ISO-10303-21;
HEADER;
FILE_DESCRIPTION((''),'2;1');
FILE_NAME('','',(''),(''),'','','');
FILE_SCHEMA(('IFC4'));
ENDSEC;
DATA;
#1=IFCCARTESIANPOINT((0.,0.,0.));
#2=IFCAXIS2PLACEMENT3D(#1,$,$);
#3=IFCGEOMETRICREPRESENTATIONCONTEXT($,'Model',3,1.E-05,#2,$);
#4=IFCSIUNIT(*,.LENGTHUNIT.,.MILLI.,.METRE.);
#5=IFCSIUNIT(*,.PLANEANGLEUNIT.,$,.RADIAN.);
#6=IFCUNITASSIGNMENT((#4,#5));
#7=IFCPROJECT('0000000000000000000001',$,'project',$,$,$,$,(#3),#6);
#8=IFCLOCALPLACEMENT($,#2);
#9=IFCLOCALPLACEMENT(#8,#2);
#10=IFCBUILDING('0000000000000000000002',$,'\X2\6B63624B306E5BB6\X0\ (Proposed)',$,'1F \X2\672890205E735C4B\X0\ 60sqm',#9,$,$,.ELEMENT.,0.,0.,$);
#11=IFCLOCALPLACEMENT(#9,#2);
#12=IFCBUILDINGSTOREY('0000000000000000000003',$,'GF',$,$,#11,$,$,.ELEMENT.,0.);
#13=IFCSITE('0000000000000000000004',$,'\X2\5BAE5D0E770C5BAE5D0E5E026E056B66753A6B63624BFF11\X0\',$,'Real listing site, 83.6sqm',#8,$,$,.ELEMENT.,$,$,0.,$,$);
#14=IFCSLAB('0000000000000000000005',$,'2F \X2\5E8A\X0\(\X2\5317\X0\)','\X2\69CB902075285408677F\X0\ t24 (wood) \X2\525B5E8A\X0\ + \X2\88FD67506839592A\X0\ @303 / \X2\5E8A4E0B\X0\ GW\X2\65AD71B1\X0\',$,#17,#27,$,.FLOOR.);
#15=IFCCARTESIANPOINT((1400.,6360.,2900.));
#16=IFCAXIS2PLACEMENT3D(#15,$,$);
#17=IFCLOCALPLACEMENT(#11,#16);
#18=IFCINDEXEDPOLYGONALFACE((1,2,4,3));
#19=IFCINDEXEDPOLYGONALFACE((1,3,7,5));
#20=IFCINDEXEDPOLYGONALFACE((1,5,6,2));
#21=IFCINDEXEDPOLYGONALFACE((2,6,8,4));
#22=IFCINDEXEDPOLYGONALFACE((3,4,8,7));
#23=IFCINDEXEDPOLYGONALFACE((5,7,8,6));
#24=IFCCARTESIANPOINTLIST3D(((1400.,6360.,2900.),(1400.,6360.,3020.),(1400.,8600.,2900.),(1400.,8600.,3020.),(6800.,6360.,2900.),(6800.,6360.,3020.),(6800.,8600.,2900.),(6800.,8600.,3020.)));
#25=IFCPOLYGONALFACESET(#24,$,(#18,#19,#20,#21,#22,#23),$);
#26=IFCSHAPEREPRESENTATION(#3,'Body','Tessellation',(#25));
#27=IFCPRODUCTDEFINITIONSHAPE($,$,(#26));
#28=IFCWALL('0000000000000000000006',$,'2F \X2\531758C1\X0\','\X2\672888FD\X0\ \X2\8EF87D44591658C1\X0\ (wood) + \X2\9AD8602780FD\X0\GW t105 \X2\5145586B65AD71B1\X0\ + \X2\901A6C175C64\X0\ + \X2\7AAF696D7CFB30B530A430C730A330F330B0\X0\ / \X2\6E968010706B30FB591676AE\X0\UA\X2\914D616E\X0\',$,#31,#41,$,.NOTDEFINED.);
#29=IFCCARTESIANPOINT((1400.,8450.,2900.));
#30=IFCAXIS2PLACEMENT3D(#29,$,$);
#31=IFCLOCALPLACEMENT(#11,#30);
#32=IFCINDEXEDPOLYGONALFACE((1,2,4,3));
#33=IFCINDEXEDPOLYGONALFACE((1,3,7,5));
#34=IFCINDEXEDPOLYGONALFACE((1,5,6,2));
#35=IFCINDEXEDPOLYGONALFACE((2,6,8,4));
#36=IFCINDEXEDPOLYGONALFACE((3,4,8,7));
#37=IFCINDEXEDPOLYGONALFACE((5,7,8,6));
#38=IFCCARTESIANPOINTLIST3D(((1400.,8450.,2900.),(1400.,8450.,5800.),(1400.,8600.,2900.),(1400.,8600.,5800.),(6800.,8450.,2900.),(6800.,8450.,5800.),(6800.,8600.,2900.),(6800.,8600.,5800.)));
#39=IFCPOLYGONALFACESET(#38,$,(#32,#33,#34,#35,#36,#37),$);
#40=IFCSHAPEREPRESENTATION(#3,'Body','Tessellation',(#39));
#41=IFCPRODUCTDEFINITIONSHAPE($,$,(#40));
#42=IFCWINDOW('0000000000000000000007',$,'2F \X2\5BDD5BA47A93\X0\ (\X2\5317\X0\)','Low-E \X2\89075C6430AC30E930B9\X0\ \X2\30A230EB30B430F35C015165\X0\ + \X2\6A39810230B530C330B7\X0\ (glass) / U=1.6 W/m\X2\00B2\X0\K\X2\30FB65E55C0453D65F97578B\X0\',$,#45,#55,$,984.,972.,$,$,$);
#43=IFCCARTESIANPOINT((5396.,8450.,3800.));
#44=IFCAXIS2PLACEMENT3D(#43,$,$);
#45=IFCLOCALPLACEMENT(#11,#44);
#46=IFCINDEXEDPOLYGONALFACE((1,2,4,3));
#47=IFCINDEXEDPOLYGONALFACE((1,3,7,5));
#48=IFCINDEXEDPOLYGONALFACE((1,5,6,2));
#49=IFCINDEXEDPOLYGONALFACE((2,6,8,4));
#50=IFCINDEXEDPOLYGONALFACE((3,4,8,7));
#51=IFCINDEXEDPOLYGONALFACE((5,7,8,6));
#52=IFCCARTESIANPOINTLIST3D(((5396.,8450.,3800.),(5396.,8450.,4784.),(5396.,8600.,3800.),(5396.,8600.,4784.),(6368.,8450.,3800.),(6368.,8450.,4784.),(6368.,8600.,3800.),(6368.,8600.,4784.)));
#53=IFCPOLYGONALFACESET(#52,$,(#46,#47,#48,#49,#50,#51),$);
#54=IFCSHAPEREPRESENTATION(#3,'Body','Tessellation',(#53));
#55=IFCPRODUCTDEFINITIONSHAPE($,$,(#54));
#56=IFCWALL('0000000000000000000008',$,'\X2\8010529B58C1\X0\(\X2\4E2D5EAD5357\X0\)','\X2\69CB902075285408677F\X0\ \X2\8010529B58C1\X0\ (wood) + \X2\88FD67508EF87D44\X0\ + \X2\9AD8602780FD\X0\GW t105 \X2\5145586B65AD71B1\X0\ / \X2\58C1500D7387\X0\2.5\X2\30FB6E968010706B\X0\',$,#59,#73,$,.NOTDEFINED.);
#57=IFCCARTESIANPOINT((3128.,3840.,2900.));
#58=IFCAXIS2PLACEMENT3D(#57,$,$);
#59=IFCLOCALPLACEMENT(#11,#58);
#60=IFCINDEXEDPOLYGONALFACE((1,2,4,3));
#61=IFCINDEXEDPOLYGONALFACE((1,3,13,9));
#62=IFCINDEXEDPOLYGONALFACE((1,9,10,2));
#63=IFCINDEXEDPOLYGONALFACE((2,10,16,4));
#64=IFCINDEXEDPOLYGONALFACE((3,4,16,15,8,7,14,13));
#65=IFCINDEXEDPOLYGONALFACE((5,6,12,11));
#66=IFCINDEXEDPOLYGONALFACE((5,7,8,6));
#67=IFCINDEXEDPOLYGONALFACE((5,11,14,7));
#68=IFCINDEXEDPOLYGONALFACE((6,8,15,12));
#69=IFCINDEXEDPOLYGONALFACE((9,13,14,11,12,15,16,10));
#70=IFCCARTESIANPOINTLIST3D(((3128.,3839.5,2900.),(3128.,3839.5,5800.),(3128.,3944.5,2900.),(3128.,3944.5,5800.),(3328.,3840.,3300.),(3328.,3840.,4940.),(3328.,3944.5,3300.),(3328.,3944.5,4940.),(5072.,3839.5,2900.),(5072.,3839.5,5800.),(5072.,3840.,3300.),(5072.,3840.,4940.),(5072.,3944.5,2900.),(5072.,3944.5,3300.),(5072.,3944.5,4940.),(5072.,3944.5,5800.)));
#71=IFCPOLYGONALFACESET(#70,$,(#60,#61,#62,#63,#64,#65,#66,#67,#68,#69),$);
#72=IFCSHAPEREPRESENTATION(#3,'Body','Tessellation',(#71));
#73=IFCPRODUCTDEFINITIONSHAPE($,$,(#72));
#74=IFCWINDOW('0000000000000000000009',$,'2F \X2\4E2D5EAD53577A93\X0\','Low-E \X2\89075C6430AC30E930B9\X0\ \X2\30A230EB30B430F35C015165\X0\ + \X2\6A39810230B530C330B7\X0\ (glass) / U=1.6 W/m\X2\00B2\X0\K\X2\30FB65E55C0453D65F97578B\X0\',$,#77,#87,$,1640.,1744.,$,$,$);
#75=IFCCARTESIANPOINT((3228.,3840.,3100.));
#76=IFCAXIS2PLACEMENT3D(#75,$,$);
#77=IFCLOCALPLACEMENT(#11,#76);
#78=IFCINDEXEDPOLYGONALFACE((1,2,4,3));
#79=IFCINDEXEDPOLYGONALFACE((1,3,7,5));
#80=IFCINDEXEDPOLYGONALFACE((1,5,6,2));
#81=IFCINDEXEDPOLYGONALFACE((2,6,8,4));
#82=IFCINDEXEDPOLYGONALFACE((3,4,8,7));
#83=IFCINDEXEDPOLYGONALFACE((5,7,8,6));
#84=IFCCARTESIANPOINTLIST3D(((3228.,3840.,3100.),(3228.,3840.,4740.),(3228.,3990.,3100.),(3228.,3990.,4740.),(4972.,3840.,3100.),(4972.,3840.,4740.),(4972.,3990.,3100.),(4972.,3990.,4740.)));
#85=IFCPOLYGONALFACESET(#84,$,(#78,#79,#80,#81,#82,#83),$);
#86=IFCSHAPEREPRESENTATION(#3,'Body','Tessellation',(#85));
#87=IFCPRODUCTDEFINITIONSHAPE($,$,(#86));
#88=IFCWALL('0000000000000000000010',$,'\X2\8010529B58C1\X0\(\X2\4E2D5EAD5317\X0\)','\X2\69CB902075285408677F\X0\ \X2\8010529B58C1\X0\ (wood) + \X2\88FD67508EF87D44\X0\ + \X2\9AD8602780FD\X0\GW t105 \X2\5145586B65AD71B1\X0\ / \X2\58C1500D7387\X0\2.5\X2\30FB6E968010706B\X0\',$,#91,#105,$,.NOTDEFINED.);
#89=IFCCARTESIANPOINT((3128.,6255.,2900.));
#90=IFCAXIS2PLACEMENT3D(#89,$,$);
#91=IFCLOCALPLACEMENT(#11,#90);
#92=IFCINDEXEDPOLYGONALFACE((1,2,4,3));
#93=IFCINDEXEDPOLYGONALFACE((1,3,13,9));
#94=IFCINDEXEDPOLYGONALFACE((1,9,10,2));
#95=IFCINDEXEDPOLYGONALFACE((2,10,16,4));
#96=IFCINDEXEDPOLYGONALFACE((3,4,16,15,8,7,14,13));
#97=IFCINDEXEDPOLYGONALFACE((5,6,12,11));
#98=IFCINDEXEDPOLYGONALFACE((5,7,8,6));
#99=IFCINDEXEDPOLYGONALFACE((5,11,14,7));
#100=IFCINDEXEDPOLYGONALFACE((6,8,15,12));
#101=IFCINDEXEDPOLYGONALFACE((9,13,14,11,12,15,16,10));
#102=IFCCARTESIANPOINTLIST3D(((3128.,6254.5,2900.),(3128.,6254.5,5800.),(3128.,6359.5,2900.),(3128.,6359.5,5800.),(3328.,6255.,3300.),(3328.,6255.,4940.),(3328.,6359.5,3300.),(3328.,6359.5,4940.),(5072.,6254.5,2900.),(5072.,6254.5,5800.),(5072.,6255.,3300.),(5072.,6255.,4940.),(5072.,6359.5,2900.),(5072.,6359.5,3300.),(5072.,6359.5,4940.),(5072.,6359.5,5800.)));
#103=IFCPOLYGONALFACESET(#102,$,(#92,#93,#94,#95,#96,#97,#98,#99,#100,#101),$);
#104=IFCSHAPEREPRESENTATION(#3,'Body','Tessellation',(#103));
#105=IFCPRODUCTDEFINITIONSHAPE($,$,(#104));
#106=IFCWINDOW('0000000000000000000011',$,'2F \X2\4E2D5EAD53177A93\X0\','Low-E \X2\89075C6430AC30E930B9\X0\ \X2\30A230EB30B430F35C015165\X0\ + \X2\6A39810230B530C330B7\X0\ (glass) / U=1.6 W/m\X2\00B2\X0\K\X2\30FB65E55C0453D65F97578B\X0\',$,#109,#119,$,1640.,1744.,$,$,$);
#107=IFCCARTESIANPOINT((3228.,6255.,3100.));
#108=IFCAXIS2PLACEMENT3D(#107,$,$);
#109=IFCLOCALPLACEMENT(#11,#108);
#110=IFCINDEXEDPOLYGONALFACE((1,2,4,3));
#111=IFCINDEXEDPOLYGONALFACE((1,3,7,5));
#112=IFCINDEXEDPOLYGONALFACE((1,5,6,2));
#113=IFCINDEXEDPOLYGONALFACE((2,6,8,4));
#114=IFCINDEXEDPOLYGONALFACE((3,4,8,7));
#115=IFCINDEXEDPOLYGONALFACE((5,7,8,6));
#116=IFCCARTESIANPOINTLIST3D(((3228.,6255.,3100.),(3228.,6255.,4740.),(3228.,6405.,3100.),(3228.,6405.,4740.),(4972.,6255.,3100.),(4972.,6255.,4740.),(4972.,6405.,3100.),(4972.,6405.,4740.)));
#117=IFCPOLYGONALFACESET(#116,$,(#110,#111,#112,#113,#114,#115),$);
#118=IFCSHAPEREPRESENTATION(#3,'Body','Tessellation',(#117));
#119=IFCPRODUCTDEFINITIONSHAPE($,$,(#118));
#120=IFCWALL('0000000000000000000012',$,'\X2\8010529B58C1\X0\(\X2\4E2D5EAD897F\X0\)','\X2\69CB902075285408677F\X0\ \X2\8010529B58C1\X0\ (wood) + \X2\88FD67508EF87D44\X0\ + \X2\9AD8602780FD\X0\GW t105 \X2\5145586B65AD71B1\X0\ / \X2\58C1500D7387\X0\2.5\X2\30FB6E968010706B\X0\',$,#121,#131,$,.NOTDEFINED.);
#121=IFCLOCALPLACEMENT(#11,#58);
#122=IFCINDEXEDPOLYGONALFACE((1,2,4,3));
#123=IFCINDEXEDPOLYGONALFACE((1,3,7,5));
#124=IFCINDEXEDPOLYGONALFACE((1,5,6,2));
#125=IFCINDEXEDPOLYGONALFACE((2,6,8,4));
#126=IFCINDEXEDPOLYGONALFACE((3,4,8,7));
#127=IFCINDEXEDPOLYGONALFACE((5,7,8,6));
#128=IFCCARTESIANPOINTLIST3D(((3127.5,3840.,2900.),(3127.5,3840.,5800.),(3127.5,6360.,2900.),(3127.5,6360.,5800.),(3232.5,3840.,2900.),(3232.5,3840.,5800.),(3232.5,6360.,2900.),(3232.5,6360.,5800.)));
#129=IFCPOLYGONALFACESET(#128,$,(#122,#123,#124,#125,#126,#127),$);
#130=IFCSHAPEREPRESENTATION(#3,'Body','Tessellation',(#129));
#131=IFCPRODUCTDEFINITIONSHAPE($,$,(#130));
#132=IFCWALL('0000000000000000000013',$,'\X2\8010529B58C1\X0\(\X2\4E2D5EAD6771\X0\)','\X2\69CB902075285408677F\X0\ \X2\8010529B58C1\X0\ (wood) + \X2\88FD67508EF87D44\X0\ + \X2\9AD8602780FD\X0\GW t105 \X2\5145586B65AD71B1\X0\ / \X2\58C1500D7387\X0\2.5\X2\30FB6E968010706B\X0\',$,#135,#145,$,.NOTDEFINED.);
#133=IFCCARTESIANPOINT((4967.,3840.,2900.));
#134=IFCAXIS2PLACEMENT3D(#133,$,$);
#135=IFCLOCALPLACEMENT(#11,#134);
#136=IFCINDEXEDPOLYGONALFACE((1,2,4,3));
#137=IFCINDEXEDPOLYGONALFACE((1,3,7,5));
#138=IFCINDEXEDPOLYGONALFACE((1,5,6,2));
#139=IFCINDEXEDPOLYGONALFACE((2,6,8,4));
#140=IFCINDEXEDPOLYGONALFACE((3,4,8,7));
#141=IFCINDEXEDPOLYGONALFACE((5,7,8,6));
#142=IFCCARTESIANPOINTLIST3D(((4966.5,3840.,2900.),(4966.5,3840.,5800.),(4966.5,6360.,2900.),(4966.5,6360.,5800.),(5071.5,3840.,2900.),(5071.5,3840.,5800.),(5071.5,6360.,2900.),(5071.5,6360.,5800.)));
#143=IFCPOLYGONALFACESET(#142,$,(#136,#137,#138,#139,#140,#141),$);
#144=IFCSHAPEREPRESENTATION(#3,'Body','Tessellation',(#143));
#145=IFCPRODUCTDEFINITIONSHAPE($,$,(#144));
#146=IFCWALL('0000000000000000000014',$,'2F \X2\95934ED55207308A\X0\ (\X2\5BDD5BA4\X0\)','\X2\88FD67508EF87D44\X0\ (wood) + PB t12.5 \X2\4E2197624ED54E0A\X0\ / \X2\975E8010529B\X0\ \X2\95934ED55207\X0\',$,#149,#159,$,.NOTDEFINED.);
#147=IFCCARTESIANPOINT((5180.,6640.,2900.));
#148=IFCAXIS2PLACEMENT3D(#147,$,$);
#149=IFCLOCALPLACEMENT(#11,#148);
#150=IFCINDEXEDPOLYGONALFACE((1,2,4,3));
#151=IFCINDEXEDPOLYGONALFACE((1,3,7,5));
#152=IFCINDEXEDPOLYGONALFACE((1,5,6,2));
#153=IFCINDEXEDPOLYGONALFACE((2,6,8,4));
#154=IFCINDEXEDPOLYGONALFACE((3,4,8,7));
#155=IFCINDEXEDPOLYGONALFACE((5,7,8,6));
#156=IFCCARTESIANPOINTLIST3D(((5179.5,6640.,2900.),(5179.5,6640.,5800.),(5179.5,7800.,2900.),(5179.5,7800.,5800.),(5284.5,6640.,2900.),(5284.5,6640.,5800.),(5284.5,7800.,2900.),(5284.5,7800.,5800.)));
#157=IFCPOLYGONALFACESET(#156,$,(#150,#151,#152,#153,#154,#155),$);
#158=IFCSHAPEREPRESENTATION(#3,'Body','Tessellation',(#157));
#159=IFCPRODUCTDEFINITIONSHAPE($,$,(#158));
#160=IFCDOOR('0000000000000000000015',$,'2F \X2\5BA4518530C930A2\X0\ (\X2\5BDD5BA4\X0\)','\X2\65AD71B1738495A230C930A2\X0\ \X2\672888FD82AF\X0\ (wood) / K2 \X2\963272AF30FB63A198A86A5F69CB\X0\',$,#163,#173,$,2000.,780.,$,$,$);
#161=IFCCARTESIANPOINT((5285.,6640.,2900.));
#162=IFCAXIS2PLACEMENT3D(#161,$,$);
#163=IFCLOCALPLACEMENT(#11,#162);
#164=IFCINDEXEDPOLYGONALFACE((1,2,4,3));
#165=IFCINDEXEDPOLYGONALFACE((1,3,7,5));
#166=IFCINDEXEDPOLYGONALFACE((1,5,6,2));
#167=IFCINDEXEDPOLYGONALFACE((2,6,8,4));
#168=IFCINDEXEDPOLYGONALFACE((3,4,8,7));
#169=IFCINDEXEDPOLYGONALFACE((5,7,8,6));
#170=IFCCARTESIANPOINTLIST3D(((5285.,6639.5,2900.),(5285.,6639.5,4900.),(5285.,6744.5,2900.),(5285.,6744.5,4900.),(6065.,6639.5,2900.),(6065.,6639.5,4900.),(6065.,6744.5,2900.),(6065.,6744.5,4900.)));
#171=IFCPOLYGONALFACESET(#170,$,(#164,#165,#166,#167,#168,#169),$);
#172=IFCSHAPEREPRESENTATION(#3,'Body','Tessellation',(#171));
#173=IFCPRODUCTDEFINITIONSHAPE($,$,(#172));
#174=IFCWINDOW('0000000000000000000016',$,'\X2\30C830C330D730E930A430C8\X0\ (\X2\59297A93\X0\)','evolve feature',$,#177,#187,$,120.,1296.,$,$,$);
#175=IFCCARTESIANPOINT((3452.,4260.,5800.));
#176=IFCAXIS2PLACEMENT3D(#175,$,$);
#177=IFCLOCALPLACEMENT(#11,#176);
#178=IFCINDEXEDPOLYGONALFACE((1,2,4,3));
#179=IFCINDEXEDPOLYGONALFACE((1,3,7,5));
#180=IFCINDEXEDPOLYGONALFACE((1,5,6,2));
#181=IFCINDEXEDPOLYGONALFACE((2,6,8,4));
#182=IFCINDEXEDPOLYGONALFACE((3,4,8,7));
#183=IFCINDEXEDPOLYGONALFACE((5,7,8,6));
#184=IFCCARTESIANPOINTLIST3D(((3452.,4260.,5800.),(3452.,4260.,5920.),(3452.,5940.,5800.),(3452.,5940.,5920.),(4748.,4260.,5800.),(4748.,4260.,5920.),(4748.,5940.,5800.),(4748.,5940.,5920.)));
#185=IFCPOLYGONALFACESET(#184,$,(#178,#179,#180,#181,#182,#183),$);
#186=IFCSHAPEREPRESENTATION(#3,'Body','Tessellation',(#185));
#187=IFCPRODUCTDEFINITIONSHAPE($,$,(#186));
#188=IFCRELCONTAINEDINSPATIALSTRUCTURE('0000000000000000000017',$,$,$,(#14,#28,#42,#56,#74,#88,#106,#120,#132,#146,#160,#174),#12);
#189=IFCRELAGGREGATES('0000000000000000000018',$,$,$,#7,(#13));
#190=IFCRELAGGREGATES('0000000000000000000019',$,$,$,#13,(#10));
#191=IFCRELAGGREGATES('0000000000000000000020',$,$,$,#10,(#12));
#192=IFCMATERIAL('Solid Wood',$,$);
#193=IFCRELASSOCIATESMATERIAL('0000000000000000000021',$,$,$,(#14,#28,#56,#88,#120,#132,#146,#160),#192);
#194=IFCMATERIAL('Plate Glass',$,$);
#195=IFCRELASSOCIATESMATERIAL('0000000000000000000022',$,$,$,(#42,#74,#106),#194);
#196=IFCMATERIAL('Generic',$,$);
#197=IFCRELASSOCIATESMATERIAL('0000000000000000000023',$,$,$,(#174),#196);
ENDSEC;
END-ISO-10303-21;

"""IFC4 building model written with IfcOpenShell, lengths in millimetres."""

from ifc_helpers import new_model, si_unit, frame, frame_2d, origin, place, context, project, spatial, rectangle, extrude, material, element, fill, save


model = new_model("IFC4")

# Units and contexts
model_context = context("Model", 3, precision=1e-05, world=origin())
ifc_project = project(units=[si_unit("LENGTHUNIT", "METRE", prefix="MILLI"), si_unit("PLANEANGLEUNIT", "RADIAN")], contexts=[model_context])

# Site, building, storey
site_placement = place(None, origin())
site = spatial("IfcSite", under=ifc_project, at=site_placement, Name="宮崎県宮崎市清武町正手１", ObjectType="Real listing site, 83.6sqm", CompositionType="ELEMENT", RefElevation=0.0)
building_placement = place(site_placement, origin())
building = spatial("IfcBuilding", under=site, at=building_placement, Name="正手の家 (Proposed)", ObjectType="1F 木造平屋 60sqm", CompositionType="ELEMENT", ElevationOfRefHeight=0.0, ElevationOfTerrain=0.0)
storey_placement = place(building_placement, origin())
storey = spatial("IfcBuildingStorey", under=building, at=storey_placement, Name="GF", CompositionType="ELEMENT", Elevation=0.0)

# Slab
ifc_material_1 = material(Name="Solid Wood")
slab_placement = place(storey_placement, frame((1400.0, 6360.0, 2900.0)))
element("IfcSlab", 1, at=slab_placement, inside=storey, material=ifc_material_1, Name="2F 床(北)", Description="構造用合板 t24 (wood) 剛床 + 製材根太 @303 / 床下 GW断熱", PredefinedType="FLOOR", context=model_context, shape_type="SweptSolid", body=[
    extrude(rectangle(XDim=5400.0, YDim=2240.0, at=frame_2d((2700.0, 1120.0))), frame((1400.0, 6360.0, 2900.0)), (0.0, 0.0, 1.0), 120.0),
])

# Walls, openings, windows
wall_1_placement = place(storey_placement, frame((1400.0, 8450.0, 2900.0)))
wall_1 = element("IfcWall", 2, at=wall_1_placement, inside=storey, material=ifc_material_1, Name="2F 北壁", Description="木製 軸組外壁 (wood) + 高性能GW t105 充填断熱 + 通気層 + 窯業系サイディング / 準耐火・外皮UA配慮", PredefinedType="NOTDEFINED", context=model_context, shape_type="SweptSolid", body=[
    extrude(rectangle(XDim=5400.0, YDim=150.0, at=frame_2d((2700.0, 75.0))), frame((1400.0, 8450.0, 2900.0)), (0.0, 0.0, 1.0), 2900.0),
])
opening_1_placement = place(storey_placement, frame((5396.0, 8450.0, 3800.0)))
opening_1 = element("IfcOpeningElement", 3, at=opening_1_placement, cuts=wall_1, PredefinedType="NOTDEFINED", context=model_context, shape_type="SweptSolid", body=[
    extrude(rectangle(XDim=972.0, YDim=150.0, at=frame_2d((486.0, 75.0))), frame((5396.0, 8450.0, 3800.0)), (0.0, 0.0, 1.0), 984.0),
])
ifc_material_2 = material(Name="Plate Glass")
window_1_placement = place(storey_placement, frame((5396.0, 8450.0, 3800.0)))
window_1 = element("IfcWindow", 4, at=window_1_placement, inside=storey, material=ifc_material_2, Name="2F 寝室窓 (北)", Description="Low-E 複層ガラス アルゴン封入 + 樹脂サッシ (glass) / U=1.6 W/m²K・日射取得型", OverallHeight=984.0, OverallWidth=972.0, context=model_context, shape_type="SweptSolid", body=[
    extrude(rectangle(XDim=972.0, YDim=150.0, at=frame_2d((486.0, 75.0))), frame((5396.0, 8450.0, 3800.0)), (0.0, 0.0, 1.0), 984.0),
])
fill(opening_1, window_1)
wall_2_placement = place(storey_placement, frame((3128.0, 3840.0, 2900.0)))
wall_2 = element("IfcWall", 5, at=wall_2_placement, inside=storey, material=ifc_material_1, Name="耐力壁(中庭南)", Description="構造用合板 耐力壁 (wood) + 製材軸組 + 高性能GW t105 充填断熱 / 壁倍率2.5・準耐火", PredefinedType="NOTDEFINED", context=model_context, shape_type="SweptSolid", body=[
    extrude(rectangle(XDim=1944.0, YDim=105.0, at=frame_2d((972.0, 52.0))), frame((3128.0, 3840.0, 2900.0)), (0.0, 0.0, 1.0), 2900.0),
])
opening_2_placement = place(storey_placement, frame((3228.0, 3840.0, 3100.0)))
opening_2 = element("IfcOpeningElement", 6, at=opening_2_placement, cuts=wall_2, PredefinedType="NOTDEFINED", context=model_context, shape_type="SweptSolid", body=[
    extrude(rectangle(XDim=1744.0, YDim=150.0, at=frame_2d((872.0, 75.0))), frame((3228.0, 3840.0, 3100.0)), (0.0, 0.0, 1.0), 1640.0),
])
window_2_placement = place(storey_placement, frame((3228.0, 3840.0, 3100.0)))
window_2 = element("IfcWindow", 7, at=window_2_placement, inside=storey, material=ifc_material_2, Name="2F 中庭南窓", Description="Low-E 複層ガラス アルゴン封入 + 樹脂サッシ (glass) / U=1.6 W/m²K・日射取得型", OverallHeight=1640.0, OverallWidth=1744.0, context=model_context, shape_type="SweptSolid", body=[
    extrude(rectangle(XDim=1744.0, YDim=150.0, at=frame_2d((872.0, 75.0))), frame((3228.0, 3840.0, 3100.0)), (0.0, 0.0, 1.0), 1640.0),
])
fill(opening_2, window_2)
wall_3_placement = place(storey_placement, frame((3128.0, 6255.0, 2900.0)))
wall_3 = element("IfcWall", 8, at=wall_3_placement, inside=storey, material=ifc_material_1, Name="耐力壁(中庭北)", Description="構造用合板 耐力壁 (wood) + 製材軸組 + 高性能GW t105 充填断熱 / 壁倍率2.5・準耐火", PredefinedType="NOTDEFINED", context=model_context, shape_type="SweptSolid", body=[
    extrude(rectangle(XDim=1944.0, YDim=105.0, at=frame_2d((972.0, 52.0))), frame((3128.0, 6255.0, 2900.0)), (0.0, 0.0, 1.0), 2900.0),
])
opening_3_placement = place(storey_placement, frame((3228.0, 6255.0, 3100.0)))
opening_3 = element("IfcOpeningElement", 9, at=opening_3_placement, cuts=wall_3, PredefinedType="NOTDEFINED", context=model_context, shape_type="SweptSolid", body=[
    extrude(rectangle(XDim=1744.0, YDim=150.0, at=frame_2d((872.0, 75.0))), frame((3228.0, 6255.0, 3100.0)), (0.0, 0.0, 1.0), 1640.0),
])
window_3_placement = place(storey_placement, frame((3228.0, 6255.0, 3100.0)))
window_3 = element("IfcWindow", 10, at=window_3_placement, inside=storey, material=ifc_material_2, Name="2F 中庭北窓", Description="Low-E 複層ガラス アルゴン封入 + 樹脂サッシ (glass) / U=1.6 W/m²K・日射取得型", OverallHeight=1640.0, OverallWidth=1744.0, context=model_context, shape_type="SweptSolid", body=[
    extrude(rectangle(XDim=1744.0, YDim=150.0, at=frame_2d((872.0, 75.0))), frame((3228.0, 6255.0, 3100.0)), (0.0, 0.0, 1.0), 1640.0),
])
fill(opening_3, window_3)

# Walls
wall_4_placement = place(storey_placement, frame((3128.0, 3840.0, 2900.0)))
element("IfcWall", 11, at=wall_4_placement, inside=storey, material=ifc_material_1, Name="耐力壁(中庭西)", Description="構造用合板 耐力壁 (wood) + 製材軸組 + 高性能GW t105 充填断熱 / 壁倍率2.5・準耐火", PredefinedType="NOTDEFINED", context=model_context, shape_type="SweptSolid", body=[
    extrude(rectangle(XDim=105.0, YDim=2520.0, at=frame_2d((52.0, 1260.0))), frame((3128.0, 3840.0, 2900.0)), (0.0, 0.0, 1.0), 2900.0),
])
wall_5_placement = place(storey_placement, frame((4967.0, 3840.0, 2900.0)))
element("IfcWall", 12, at=wall_5_placement, inside=storey, material=ifc_material_1, Name="耐力壁(中庭東)", Description="構造用合板 耐力壁 (wood) + 製材軸組 + 高性能GW t105 充填断熱 / 壁倍率2.5・準耐火", PredefinedType="NOTDEFINED", context=model_context, shape_type="SweptSolid", body=[
    extrude(rectangle(XDim=105.0, YDim=2520.0, at=frame_2d((52.0, 1260.0))), frame((4967.0, 3840.0, 2900.0)), (0.0, 0.0, 1.0), 2900.0),
])
wall_6_placement = place(storey_placement, frame((5180.0, 6640.0, 2900.0)))
element("IfcWall", 13, at=wall_6_placement, inside=storey, material=ifc_material_1, Name="2F 間仕切り (寝室)", Description="製材軸組 (wood) + PB t12.5 両面仕上 / 非耐力 間仕切", PredefinedType="NOTDEFINED", context=model_context, shape_type="SweptSolid", body=[
    extrude(rectangle(XDim=105.0, YDim=1160.0, at=frame_2d((52.0, 580.0))), frame((5180.0, 6640.0, 2900.0)), (0.0, 0.0, 1.0), 2900.0),
])

# Door
door_placement = place(storey_placement, frame((5285.0, 6640.0, 2900.0)))
element("IfcDoor", 14, at=door_placement, inside=storey, material=ifc_material_1, Name="2F 室内ドア (寝室)", Description="断熱玄関ドア 木製芯 (wood) / K2 防犯・採風機構", OverallHeight=2000.0, OverallWidth=780.0, context=model_context, shape_type="SweptSolid", body=[
    extrude(rectangle(XDim=780.0, YDim=105.0, at=frame_2d((390.0, 52.0))), frame((5285.0, 6640.0, 2900.0)), (0.0, 0.0, 1.0), 2000.0),
])

# Window
ifc_material_3 = material(Name="Generic")
window_4_placement = place(storey_placement, frame((3452.0, 4260.0, 5800.0)))
element("IfcWindow", 15, at=window_4_placement, inside=storey, material=ifc_material_3, Name="トップライト (天窓)", Description="evolve feature", OverallHeight=120.0, OverallWidth=1296.0, context=model_context, shape_type="SweptSolid", body=[
    extrude(rectangle(XDim=1296.0, YDim=1680.0, at=frame_2d((648.0, 840.0))), frame((3452.0, 4260.0, 5800.0)), (0.0, 0.0, 1.0), 120.0),
])

save(model, "model.ifc")
